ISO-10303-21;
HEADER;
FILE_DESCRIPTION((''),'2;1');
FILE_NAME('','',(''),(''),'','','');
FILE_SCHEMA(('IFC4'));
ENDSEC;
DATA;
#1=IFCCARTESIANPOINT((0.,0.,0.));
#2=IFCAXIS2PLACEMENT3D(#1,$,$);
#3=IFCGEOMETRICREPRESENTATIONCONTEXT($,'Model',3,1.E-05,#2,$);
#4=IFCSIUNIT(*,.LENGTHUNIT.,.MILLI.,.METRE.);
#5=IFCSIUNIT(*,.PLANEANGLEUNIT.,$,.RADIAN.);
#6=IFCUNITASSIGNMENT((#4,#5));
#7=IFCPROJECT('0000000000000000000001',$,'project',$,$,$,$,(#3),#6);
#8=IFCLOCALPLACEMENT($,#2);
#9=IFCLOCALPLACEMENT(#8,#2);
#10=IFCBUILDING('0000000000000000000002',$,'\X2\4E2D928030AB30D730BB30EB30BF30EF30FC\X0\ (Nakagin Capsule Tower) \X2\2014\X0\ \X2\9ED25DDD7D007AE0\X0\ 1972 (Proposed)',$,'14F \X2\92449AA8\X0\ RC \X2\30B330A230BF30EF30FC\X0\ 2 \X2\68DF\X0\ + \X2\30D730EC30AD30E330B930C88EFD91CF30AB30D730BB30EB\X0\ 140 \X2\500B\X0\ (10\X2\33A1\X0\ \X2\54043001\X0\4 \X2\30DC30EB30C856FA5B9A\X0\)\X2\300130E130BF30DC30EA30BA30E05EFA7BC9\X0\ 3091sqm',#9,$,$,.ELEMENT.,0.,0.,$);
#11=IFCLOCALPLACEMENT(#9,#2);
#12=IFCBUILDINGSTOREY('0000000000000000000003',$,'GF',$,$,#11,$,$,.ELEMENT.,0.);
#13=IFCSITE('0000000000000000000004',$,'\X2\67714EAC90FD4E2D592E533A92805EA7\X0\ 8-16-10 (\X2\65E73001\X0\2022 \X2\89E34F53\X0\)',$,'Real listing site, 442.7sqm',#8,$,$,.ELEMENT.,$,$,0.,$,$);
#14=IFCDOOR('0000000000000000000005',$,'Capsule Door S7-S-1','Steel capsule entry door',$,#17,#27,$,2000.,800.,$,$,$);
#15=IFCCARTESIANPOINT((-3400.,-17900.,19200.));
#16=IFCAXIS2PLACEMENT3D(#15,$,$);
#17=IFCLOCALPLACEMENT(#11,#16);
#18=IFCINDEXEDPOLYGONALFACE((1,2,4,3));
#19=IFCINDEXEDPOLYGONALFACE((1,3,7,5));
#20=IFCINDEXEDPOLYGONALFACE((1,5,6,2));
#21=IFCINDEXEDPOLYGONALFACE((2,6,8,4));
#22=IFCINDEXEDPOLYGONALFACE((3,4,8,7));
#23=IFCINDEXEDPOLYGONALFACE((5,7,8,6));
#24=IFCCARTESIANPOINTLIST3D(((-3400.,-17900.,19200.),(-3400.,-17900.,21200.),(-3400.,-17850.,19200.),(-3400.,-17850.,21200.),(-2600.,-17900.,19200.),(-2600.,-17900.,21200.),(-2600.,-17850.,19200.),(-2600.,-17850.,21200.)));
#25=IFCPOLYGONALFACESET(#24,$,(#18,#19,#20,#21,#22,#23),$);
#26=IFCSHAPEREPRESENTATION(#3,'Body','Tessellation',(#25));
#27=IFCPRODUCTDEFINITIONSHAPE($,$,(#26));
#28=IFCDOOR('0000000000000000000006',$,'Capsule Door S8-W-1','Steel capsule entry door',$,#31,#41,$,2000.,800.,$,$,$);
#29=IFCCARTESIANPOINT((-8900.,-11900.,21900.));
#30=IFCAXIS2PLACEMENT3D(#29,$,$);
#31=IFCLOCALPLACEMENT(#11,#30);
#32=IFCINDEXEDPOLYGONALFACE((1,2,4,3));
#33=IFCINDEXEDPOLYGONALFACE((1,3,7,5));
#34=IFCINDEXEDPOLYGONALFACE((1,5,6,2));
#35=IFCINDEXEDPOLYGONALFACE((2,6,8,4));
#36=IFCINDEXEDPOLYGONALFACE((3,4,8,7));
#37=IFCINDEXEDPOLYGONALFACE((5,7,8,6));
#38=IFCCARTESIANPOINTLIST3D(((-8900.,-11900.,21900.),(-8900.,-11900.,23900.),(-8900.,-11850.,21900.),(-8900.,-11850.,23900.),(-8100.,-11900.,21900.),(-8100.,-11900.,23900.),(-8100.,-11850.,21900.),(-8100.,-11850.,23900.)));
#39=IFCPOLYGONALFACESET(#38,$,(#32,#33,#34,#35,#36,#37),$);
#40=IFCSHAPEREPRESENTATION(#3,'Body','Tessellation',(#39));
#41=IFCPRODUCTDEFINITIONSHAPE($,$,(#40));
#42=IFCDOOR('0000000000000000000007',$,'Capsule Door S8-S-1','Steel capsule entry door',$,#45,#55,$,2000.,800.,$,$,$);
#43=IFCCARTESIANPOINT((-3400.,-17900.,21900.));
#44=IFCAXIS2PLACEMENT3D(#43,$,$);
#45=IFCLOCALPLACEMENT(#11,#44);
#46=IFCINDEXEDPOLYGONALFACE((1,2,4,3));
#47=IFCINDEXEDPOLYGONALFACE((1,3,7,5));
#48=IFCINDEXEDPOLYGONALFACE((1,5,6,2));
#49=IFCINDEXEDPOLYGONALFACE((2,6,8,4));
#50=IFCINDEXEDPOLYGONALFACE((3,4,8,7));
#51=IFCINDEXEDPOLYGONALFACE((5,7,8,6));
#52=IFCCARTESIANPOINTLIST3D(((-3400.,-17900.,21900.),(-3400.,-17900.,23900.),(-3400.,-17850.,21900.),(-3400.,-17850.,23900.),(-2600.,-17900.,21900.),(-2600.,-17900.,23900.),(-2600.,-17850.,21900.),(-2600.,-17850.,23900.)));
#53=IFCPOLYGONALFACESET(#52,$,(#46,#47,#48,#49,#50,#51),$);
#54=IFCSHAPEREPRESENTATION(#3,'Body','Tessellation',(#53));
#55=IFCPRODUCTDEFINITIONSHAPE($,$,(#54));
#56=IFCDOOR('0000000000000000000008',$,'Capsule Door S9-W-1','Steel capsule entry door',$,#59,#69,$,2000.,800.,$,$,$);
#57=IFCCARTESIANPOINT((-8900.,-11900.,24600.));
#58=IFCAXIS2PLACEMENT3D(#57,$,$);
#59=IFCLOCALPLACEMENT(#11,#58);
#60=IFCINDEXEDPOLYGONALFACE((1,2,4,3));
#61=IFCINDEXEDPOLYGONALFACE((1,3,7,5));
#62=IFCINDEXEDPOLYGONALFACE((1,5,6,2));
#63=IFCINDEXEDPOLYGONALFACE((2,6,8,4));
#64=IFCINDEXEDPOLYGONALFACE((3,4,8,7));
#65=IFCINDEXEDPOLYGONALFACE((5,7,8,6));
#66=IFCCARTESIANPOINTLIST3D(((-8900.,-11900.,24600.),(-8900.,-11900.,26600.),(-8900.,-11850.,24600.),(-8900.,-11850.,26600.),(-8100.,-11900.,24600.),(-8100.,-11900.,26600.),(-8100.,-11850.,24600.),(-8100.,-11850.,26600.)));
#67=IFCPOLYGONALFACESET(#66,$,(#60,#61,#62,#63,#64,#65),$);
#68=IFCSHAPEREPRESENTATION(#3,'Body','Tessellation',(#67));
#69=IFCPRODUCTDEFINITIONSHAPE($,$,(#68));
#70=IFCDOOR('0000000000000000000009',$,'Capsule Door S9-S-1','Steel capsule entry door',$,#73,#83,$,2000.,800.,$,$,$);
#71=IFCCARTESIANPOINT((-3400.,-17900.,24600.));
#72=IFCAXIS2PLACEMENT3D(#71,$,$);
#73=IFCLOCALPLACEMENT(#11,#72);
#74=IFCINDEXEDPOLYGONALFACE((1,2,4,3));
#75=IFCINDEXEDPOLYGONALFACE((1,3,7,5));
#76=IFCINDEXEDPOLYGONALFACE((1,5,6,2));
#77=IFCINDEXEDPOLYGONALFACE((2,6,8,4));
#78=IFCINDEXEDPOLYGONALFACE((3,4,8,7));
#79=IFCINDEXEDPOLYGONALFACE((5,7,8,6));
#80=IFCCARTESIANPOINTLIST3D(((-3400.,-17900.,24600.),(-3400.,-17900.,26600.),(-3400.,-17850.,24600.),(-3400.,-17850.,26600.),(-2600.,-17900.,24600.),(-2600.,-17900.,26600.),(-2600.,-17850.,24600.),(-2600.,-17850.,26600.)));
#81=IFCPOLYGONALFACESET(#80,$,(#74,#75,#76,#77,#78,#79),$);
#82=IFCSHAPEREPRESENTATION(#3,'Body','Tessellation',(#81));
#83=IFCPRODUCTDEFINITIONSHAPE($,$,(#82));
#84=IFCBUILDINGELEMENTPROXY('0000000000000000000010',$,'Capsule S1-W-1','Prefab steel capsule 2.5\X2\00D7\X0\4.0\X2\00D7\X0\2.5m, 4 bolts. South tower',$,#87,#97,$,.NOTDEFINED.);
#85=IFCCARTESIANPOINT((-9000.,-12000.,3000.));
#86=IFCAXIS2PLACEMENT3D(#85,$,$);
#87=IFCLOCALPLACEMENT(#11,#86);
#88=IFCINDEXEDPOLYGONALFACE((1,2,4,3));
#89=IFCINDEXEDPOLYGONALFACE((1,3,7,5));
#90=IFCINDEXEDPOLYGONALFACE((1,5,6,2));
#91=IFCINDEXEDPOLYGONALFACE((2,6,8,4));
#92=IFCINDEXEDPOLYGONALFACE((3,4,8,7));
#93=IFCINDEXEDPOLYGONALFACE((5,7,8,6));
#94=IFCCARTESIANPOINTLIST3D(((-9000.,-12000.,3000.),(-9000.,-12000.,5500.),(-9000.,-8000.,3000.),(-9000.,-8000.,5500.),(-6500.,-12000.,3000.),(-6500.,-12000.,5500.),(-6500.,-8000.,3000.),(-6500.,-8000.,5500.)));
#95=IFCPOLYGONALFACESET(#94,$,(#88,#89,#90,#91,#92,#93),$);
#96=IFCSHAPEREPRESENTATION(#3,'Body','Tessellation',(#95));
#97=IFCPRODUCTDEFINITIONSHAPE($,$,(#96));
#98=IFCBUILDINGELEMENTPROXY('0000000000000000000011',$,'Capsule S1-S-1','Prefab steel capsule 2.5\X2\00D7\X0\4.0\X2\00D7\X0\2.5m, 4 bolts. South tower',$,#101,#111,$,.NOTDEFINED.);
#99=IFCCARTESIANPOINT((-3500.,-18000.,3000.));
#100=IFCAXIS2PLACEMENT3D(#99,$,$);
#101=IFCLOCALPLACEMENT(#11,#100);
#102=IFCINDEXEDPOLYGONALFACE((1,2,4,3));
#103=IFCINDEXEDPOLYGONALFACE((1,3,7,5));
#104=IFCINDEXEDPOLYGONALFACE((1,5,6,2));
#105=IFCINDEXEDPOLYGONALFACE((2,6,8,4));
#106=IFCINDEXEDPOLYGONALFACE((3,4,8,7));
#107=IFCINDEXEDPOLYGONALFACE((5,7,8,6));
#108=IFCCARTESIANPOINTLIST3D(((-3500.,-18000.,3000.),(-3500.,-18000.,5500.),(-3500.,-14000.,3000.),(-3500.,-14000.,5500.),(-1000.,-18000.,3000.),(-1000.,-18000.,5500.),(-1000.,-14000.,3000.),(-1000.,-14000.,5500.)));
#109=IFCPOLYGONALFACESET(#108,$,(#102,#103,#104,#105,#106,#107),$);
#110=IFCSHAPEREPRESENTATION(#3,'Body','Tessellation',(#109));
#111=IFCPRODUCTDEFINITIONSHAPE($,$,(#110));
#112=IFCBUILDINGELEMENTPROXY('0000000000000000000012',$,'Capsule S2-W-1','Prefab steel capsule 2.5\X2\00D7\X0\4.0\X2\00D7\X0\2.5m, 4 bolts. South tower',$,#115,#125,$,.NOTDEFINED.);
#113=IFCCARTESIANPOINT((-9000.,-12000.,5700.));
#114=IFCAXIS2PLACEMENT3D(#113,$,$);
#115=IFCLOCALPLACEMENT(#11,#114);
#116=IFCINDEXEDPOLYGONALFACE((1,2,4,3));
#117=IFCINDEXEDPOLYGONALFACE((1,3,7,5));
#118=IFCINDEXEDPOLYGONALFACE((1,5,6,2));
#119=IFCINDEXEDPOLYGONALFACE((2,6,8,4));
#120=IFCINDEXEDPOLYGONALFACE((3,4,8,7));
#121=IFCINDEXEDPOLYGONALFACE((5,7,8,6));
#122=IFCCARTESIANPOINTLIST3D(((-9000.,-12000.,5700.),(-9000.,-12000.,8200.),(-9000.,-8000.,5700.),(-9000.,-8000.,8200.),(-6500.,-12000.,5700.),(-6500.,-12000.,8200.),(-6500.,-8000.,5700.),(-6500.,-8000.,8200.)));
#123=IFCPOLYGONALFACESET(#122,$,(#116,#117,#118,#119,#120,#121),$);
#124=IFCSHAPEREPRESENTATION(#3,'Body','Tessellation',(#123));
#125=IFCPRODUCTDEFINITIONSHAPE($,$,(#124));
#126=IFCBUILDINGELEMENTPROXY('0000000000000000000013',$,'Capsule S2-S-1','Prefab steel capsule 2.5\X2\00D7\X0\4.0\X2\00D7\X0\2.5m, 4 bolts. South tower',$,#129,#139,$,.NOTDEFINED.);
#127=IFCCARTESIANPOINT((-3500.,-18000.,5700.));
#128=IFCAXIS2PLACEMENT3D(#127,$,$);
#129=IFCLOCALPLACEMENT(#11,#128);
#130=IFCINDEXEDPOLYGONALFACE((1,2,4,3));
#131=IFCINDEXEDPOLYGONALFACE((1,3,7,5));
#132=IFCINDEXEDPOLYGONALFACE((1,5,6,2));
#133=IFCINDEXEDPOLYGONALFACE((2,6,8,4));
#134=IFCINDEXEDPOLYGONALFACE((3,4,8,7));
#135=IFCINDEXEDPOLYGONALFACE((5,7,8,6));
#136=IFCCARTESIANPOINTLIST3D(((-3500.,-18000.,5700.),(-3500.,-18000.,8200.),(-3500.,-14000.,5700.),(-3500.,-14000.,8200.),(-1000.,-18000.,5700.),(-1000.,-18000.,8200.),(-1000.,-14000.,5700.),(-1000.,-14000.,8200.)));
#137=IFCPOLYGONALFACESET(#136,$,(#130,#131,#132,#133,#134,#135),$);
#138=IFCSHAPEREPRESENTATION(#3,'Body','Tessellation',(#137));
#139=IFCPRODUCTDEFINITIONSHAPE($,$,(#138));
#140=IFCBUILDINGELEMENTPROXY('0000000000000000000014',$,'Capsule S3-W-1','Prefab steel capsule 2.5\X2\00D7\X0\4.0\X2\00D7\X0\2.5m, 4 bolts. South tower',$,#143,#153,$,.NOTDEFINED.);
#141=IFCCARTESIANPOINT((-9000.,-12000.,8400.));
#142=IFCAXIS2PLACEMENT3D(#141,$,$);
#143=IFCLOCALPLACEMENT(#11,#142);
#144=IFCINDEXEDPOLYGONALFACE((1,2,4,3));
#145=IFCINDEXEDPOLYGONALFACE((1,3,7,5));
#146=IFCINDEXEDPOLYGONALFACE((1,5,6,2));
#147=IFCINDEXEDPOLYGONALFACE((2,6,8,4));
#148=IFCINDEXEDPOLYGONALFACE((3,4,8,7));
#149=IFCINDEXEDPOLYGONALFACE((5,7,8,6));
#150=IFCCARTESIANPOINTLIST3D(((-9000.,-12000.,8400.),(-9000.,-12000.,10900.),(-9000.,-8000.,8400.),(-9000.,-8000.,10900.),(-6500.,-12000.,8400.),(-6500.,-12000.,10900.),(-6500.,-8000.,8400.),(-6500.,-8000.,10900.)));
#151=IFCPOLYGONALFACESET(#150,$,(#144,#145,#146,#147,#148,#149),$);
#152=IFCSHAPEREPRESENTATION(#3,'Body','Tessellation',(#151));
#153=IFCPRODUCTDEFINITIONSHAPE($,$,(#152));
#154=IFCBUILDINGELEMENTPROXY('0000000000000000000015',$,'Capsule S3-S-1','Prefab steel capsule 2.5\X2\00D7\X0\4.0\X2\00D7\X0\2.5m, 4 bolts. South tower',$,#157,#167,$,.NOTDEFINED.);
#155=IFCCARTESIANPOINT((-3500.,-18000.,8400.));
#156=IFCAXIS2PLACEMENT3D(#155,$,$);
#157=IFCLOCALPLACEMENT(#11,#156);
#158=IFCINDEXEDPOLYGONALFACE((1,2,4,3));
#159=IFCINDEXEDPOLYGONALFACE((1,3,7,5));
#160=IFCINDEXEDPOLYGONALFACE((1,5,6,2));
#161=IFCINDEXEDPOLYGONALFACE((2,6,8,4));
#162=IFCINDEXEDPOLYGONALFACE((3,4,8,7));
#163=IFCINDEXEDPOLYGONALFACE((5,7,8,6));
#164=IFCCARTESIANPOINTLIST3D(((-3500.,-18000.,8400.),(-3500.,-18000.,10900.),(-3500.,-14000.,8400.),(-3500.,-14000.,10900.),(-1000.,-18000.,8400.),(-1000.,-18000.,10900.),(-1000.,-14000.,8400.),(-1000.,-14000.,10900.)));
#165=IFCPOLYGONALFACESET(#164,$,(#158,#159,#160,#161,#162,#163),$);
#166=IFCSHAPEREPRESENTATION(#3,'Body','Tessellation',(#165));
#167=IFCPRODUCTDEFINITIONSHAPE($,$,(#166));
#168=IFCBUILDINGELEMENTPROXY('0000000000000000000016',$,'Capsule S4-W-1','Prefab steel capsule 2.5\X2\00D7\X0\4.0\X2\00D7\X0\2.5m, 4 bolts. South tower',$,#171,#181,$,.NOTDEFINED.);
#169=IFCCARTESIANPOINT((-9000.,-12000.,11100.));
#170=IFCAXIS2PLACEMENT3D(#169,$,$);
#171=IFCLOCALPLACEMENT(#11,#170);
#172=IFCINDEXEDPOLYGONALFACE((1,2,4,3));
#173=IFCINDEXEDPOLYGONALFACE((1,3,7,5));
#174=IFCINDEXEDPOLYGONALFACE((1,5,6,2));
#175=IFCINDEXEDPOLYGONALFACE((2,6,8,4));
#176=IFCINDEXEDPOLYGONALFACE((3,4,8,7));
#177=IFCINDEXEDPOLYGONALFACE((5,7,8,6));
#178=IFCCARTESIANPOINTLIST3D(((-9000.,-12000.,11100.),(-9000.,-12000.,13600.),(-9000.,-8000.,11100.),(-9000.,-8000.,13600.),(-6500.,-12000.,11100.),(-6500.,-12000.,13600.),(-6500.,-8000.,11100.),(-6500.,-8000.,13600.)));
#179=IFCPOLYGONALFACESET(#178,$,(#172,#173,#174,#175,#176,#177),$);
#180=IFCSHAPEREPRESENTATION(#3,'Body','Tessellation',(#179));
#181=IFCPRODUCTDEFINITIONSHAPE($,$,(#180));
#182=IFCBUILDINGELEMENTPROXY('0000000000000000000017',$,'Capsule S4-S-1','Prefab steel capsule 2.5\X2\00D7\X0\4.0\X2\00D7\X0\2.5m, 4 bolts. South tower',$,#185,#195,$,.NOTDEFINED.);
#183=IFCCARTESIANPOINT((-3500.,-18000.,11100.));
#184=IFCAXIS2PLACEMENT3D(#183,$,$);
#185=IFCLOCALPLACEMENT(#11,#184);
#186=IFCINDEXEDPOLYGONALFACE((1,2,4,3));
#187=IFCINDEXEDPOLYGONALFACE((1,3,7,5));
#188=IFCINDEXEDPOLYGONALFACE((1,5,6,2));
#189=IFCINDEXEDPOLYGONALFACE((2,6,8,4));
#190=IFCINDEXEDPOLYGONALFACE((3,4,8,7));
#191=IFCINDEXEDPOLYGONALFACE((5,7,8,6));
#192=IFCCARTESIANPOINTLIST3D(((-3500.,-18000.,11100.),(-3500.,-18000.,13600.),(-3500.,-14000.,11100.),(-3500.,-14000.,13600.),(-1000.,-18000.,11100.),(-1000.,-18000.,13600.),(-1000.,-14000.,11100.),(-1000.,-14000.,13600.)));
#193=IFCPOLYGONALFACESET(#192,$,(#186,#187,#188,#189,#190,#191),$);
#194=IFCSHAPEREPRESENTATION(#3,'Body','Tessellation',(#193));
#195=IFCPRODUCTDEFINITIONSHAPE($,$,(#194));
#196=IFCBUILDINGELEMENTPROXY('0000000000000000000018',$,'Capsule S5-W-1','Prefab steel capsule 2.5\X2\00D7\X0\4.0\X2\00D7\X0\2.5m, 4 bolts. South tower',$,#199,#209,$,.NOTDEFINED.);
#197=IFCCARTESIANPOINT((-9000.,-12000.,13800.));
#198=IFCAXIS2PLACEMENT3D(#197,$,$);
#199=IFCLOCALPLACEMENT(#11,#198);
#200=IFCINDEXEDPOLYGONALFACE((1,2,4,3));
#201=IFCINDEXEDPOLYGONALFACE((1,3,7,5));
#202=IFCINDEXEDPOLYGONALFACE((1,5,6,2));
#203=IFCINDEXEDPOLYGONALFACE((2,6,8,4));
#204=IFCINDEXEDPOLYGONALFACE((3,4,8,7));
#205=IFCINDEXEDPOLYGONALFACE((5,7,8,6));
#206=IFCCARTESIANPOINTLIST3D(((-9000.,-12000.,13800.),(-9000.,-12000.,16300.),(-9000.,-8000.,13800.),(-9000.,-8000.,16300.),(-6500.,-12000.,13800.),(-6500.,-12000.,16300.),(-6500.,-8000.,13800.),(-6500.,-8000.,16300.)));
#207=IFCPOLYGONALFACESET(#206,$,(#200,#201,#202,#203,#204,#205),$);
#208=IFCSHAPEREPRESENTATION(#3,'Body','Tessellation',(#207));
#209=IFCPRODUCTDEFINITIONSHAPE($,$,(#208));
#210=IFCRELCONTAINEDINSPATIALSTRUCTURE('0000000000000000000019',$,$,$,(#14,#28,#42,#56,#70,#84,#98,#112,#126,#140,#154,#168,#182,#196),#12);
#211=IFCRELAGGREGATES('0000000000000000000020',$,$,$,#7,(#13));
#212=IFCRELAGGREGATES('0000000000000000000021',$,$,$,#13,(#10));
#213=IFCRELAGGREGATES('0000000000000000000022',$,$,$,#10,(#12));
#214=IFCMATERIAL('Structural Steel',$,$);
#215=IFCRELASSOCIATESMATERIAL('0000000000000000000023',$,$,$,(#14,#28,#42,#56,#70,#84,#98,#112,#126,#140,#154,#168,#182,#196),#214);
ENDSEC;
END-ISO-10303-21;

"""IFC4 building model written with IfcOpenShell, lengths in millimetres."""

from ifc_helpers import new_model, si_unit, frame, frame_2d, origin, place, context, project, spatial, rectangle, extrude, material, element, save


model = new_model("IFC4")

# Units and contexts
model_context = context("Model", 3, precision=1e-05, world=origin())
ifc_project = project(units=[si_unit("LENGTHUNIT", "METRE", prefix="MILLI"), si_unit("PLANEANGLEUNIT", "RADIAN")], contexts=[model_context])

# Site, building, storey
site_placement = place(None, origin())
site = spatial("IfcSite", under=ifc_project, at=site_placement, Name="東京都中央区銀座 8-16-10 (旧、2022 解体)", ObjectType="Real listing site, 442.7sqm", CompositionType="ELEMENT", RefElevation=0.0)
building_placement = place(site_placement, origin())
building = spatial("IfcBuilding", under=site, at=building_placement, Name="中銀カプセルタワー (Nakagin Capsule Tower) — 黒川紀章 1972 (Proposed)", ObjectType="14F 鉄骨 RC コアタワー 2 棟 + プレキャスト軽量カプセル 140 個 (10㎡ 各、4 ボルト固定)、メタボリズム建築 3091sqm", CompositionType="ELEMENT", ElevationOfRefHeight=0.0, ElevationOfTerrain=0.0)
storey_placement = place(building_placement, origin())
storey = spatial("IfcBuildingStorey", under=building, at=storey_placement, Name="GF", CompositionType="ELEMENT", Elevation=0.0)

# Doors
ifc_material_1 = material(Name="Structural Steel")
door_1_placement = place(storey_placement, frame((-3400.0, -17900.0, 19200.0)))
element("IfcDoor", 1, at=door_1_placement, inside=storey, material=ifc_material_1, Name="Capsule Door S7-S-1", Description="Steel capsule entry door", OverallHeight=2000.0, OverallWidth=800.0, context=model_context, shape_type="SweptSolid", body=[
    extrude(rectangle(XDim=800.0, YDim=50.0, at=frame_2d((400.0, 25.0))), frame((-3400.0, -17900.0, 19200.0)), (0.0, 0.0, 1.0), 2000.0),
])
door_2_placement = place(storey_placement, frame((-8900.0, -11900.0, 21900.0)))
element("IfcDoor", 2, at=door_2_placement, inside=storey, material=ifc_material_1, Name="Capsule Door S8-W-1", Description="Steel capsule entry door", OverallHeight=2000.0, OverallWidth=800.0, context=model_context, shape_type="SweptSolid", body=[
    extrude(rectangle(XDim=800.0, YDim=50.0, at=frame_2d((400.0, 25.0))), frame((-8900.0, -11900.0, 21900.0)), (0.0, 0.0, 1.0), 2000.0),
])
door_3_placement = place(storey_placement, frame((-3400.0, -17900.0, 21900.0)))
element("IfcDoor", 3, at=door_3_placement, inside=storey, material=ifc_material_1, Name="Capsule Door S8-S-1", Description="Steel capsule entry door", OverallHeight=2000.0, OverallWidth=800.0, context=model_context, shape_type="SweptSolid", body=[
    extrude(rectangle(XDim=800.0, YDim=50.0, at=frame_2d((400.0, 25.0))), frame((-3400.0, -17900.0, 21900.0)), (0.0, 0.0, 1.0), 2000.0),
])
door_4_placement = place(storey_placement, frame((-8900.0, -11900.0, 24600.0)))
element("IfcDoor", 4, at=door_4_placement, inside=storey, material=ifc_material_1, Name="Capsule Door S9-W-1", Description="Steel capsule entry door", OverallHeight=2000.0, OverallWidth=800.0, context=model_context, shape_type="SweptSolid", body=[
    extrude(rectangle(XDim=800.0, YDim=50.0, at=frame_2d((400.0, 25.0))), frame((-8900.0, -11900.0, 24600.0)), (0.0, 0.0, 1.0), 2000.0),
])
door_5_placement = place(storey_placement, frame((-3400.0, -17900.0, 24600.0)))
element("IfcDoor", 5, at=door_5_placement, inside=storey, material=ifc_material_1, Name="Capsule Door S9-S-1", Description="Steel capsule entry door", OverallHeight=2000.0, OverallWidth=800.0, context=model_context, shape_type="SweptSolid", body=[
    extrude(rectangle(XDim=800.0, YDim=50.0, at=frame_2d((400.0, 25.0))), frame((-3400.0, -17900.0, 24600.0)), (0.0, 0.0, 1.0), 2000.0),
])

# Building element proxies
proxy_1_placement = place(storey_placement, frame((-9000.0, -12000.0, 3000.0)))
element("IfcBuildingElementProxy", 6, at=proxy_1_placement, inside=storey, material=ifc_material_1, Name="Capsule S1-W-1", Description="Prefab steel capsule 2.5×4.0×2.5m, 4 bolts. South tower", PredefinedType="NOTDEFINED", context=model_context, shape_type="SweptSolid", body=[
    extrude(rectangle(XDim=2500.0, YDim=4000.0, at=frame_2d((1250.0, 2000.0))), frame((-9000.0, -12000.0, 3000.0)), (0.0, 0.0, 1.0), 2500.0),
])
proxy_2_placement = place(storey_placement, frame((-3500.0, -18000.0, 3000.0)))
element("IfcBuildingElementProxy", 7, at=proxy_2_placement, inside=storey, material=ifc_material_1, Name="Capsule S1-S-1", Description="Prefab steel capsule 2.5×4.0×2.5m, 4 bolts. South tower", PredefinedType="NOTDEFINED", context=model_context, shape_type="SweptSolid", body=[
    extrude(rectangle(XDim=2500.0, YDim=4000.0, at=frame_2d((1250.0, 2000.0))), frame((-3500.0, -18000.0, 3000.0)), (0.0, 0.0, 1.0), 2500.0),
])
proxy_3_placement = place(storey_placement, frame((-9000.0, -12000.0, 5700.0)))
element("IfcBuildingElementProxy", 8, at=proxy_3_placement, inside=storey, material=ifc_material_1, Name="Capsule S2-W-1", Description="Prefab steel capsule 2.5×4.0×2.5m, 4 bolts. South tower", PredefinedType="NOTDEFINED", context=model_context, shape_type="SweptSolid", body=[
    extrude(rectangle(XDim=2500.0, YDim=4000.0, at=frame_2d((1250.0, 2000.0))), frame((-9000.0, -12000.0, 5700.0)), (0.0, 0.0, 1.0), 2500.0),
])
proxy_4_placement = place(storey_placement, frame((-3500.0, -18000.0, 5700.0)))
element("IfcBuildingElementProxy", 9, at=proxy_4_placement, inside=storey, material=ifc_material_1, Name="Capsule S2-S-1", Description="Prefab steel capsule 2.5×4.0×2.5m, 4 bolts. South tower", PredefinedType="NOTDEFINED", context=model_context, shape_type="SweptSolid", body=[
    extrude(rectangle(XDim=2500.0, YDim=4000.0, at=frame_2d((1250.0, 2000.0))), frame((-3500.0, -18000.0, 5700.0)), (0.0, 0.0, 1.0), 2500.0),
])
proxy_5_placement = place(storey_placement, frame((-9000.0, -12000.0, 8400.0)))
element("IfcBuildingElementProxy", 10, at=proxy_5_placement, inside=storey, material=ifc_material_1, Name="Capsule S3-W-1", Description="Prefab steel capsule 2.5×4.0×2.5m, 4 bolts. South tower", PredefinedType="NOTDEFINED", context=model_context, shape_type="SweptSolid", body=[
    extrude(rectangle(XDim=2500.0, YDim=4000.0, at=frame_2d((1250.0, 2000.0))), frame((-9000.0, -12000.0, 8400.0)), (0.0, 0.0, 1.0), 2500.0),
])
proxy_6_placement = place(storey_placement, frame((-3500.0, -18000.0, 8400.0)))
element("IfcBuildingElementProxy", 11, at=proxy_6_placement, inside=storey, material=ifc_material_1, Name="Capsule S3-S-1", Description="Prefab steel capsule 2.5×4.0×2.5m, 4 bolts. South tower", PredefinedType="NOTDEFINED", context=model_context, shape_type="SweptSolid", body=[
    extrude(rectangle(XDim=2500.0, YDim=4000.0, at=frame_2d((1250.0, 2000.0))), frame((-3500.0, -18000.0, 8400.0)), (0.0, 0.0, 1.0), 2500.0),
])
proxy_7_placement = place(storey_placement, frame((-9000.0, -12000.0, 11100.0)))
element("IfcBuildingElementProxy", 12, at=proxy_7_placement, inside=storey, material=ifc_material_1, Name="Capsule S4-W-1", Description="Prefab steel capsule 2.5×4.0×2.5m, 4 bolts. South tower", PredefinedType="NOTDEFINED", context=model_context, shape_type="SweptSolid", body=[
    extrude(rectangle(XDim=2500.0, YDim=4000.0, at=frame_2d((1250.0, 2000.0))), frame((-9000.0, -12000.0, 11100.0)), (0.0, 0.0, 1.0), 2500.0),
])
proxy_8_placement = place(storey_placement, frame((-3500.0, -18000.0, 11100.0)))
element("IfcBuildingElementProxy", 13, at=proxy_8_placement, inside=storey, material=ifc_material_1, Name="Capsule S4-S-1", Description="Prefab steel capsule 2.5×4.0×2.5m, 4 bolts. South tower", PredefinedType="NOTDEFINED", context=model_context, shape_type="SweptSolid", body=[
    extrude(rectangle(XDim=2500.0, YDim=4000.0, at=frame_2d((1250.0, 2000.0))), frame((-3500.0, -18000.0, 11100.0)), (0.0, 0.0, 1.0), 2500.0),
])
proxy_9_placement = place(storey_placement, frame((-9000.0, -12000.0, 13800.0)))
element("IfcBuildingElementProxy", 14, at=proxy_9_placement, inside=storey, material=ifc_material_1, Name="Capsule S5-W-1", Description="Prefab steel capsule 2.5×4.0×2.5m, 4 bolts. South tower", PredefinedType="NOTDEFINED", context=model_context, shape_type="SweptSolid", body=[
    extrude(rectangle(XDim=2500.0, YDim=4000.0, at=frame_2d((1250.0, 2000.0))), frame((-9000.0, -12000.0, 13800.0)), (0.0, 0.0, 1.0), 2500.0),
])

save(model, "model.ifc")
